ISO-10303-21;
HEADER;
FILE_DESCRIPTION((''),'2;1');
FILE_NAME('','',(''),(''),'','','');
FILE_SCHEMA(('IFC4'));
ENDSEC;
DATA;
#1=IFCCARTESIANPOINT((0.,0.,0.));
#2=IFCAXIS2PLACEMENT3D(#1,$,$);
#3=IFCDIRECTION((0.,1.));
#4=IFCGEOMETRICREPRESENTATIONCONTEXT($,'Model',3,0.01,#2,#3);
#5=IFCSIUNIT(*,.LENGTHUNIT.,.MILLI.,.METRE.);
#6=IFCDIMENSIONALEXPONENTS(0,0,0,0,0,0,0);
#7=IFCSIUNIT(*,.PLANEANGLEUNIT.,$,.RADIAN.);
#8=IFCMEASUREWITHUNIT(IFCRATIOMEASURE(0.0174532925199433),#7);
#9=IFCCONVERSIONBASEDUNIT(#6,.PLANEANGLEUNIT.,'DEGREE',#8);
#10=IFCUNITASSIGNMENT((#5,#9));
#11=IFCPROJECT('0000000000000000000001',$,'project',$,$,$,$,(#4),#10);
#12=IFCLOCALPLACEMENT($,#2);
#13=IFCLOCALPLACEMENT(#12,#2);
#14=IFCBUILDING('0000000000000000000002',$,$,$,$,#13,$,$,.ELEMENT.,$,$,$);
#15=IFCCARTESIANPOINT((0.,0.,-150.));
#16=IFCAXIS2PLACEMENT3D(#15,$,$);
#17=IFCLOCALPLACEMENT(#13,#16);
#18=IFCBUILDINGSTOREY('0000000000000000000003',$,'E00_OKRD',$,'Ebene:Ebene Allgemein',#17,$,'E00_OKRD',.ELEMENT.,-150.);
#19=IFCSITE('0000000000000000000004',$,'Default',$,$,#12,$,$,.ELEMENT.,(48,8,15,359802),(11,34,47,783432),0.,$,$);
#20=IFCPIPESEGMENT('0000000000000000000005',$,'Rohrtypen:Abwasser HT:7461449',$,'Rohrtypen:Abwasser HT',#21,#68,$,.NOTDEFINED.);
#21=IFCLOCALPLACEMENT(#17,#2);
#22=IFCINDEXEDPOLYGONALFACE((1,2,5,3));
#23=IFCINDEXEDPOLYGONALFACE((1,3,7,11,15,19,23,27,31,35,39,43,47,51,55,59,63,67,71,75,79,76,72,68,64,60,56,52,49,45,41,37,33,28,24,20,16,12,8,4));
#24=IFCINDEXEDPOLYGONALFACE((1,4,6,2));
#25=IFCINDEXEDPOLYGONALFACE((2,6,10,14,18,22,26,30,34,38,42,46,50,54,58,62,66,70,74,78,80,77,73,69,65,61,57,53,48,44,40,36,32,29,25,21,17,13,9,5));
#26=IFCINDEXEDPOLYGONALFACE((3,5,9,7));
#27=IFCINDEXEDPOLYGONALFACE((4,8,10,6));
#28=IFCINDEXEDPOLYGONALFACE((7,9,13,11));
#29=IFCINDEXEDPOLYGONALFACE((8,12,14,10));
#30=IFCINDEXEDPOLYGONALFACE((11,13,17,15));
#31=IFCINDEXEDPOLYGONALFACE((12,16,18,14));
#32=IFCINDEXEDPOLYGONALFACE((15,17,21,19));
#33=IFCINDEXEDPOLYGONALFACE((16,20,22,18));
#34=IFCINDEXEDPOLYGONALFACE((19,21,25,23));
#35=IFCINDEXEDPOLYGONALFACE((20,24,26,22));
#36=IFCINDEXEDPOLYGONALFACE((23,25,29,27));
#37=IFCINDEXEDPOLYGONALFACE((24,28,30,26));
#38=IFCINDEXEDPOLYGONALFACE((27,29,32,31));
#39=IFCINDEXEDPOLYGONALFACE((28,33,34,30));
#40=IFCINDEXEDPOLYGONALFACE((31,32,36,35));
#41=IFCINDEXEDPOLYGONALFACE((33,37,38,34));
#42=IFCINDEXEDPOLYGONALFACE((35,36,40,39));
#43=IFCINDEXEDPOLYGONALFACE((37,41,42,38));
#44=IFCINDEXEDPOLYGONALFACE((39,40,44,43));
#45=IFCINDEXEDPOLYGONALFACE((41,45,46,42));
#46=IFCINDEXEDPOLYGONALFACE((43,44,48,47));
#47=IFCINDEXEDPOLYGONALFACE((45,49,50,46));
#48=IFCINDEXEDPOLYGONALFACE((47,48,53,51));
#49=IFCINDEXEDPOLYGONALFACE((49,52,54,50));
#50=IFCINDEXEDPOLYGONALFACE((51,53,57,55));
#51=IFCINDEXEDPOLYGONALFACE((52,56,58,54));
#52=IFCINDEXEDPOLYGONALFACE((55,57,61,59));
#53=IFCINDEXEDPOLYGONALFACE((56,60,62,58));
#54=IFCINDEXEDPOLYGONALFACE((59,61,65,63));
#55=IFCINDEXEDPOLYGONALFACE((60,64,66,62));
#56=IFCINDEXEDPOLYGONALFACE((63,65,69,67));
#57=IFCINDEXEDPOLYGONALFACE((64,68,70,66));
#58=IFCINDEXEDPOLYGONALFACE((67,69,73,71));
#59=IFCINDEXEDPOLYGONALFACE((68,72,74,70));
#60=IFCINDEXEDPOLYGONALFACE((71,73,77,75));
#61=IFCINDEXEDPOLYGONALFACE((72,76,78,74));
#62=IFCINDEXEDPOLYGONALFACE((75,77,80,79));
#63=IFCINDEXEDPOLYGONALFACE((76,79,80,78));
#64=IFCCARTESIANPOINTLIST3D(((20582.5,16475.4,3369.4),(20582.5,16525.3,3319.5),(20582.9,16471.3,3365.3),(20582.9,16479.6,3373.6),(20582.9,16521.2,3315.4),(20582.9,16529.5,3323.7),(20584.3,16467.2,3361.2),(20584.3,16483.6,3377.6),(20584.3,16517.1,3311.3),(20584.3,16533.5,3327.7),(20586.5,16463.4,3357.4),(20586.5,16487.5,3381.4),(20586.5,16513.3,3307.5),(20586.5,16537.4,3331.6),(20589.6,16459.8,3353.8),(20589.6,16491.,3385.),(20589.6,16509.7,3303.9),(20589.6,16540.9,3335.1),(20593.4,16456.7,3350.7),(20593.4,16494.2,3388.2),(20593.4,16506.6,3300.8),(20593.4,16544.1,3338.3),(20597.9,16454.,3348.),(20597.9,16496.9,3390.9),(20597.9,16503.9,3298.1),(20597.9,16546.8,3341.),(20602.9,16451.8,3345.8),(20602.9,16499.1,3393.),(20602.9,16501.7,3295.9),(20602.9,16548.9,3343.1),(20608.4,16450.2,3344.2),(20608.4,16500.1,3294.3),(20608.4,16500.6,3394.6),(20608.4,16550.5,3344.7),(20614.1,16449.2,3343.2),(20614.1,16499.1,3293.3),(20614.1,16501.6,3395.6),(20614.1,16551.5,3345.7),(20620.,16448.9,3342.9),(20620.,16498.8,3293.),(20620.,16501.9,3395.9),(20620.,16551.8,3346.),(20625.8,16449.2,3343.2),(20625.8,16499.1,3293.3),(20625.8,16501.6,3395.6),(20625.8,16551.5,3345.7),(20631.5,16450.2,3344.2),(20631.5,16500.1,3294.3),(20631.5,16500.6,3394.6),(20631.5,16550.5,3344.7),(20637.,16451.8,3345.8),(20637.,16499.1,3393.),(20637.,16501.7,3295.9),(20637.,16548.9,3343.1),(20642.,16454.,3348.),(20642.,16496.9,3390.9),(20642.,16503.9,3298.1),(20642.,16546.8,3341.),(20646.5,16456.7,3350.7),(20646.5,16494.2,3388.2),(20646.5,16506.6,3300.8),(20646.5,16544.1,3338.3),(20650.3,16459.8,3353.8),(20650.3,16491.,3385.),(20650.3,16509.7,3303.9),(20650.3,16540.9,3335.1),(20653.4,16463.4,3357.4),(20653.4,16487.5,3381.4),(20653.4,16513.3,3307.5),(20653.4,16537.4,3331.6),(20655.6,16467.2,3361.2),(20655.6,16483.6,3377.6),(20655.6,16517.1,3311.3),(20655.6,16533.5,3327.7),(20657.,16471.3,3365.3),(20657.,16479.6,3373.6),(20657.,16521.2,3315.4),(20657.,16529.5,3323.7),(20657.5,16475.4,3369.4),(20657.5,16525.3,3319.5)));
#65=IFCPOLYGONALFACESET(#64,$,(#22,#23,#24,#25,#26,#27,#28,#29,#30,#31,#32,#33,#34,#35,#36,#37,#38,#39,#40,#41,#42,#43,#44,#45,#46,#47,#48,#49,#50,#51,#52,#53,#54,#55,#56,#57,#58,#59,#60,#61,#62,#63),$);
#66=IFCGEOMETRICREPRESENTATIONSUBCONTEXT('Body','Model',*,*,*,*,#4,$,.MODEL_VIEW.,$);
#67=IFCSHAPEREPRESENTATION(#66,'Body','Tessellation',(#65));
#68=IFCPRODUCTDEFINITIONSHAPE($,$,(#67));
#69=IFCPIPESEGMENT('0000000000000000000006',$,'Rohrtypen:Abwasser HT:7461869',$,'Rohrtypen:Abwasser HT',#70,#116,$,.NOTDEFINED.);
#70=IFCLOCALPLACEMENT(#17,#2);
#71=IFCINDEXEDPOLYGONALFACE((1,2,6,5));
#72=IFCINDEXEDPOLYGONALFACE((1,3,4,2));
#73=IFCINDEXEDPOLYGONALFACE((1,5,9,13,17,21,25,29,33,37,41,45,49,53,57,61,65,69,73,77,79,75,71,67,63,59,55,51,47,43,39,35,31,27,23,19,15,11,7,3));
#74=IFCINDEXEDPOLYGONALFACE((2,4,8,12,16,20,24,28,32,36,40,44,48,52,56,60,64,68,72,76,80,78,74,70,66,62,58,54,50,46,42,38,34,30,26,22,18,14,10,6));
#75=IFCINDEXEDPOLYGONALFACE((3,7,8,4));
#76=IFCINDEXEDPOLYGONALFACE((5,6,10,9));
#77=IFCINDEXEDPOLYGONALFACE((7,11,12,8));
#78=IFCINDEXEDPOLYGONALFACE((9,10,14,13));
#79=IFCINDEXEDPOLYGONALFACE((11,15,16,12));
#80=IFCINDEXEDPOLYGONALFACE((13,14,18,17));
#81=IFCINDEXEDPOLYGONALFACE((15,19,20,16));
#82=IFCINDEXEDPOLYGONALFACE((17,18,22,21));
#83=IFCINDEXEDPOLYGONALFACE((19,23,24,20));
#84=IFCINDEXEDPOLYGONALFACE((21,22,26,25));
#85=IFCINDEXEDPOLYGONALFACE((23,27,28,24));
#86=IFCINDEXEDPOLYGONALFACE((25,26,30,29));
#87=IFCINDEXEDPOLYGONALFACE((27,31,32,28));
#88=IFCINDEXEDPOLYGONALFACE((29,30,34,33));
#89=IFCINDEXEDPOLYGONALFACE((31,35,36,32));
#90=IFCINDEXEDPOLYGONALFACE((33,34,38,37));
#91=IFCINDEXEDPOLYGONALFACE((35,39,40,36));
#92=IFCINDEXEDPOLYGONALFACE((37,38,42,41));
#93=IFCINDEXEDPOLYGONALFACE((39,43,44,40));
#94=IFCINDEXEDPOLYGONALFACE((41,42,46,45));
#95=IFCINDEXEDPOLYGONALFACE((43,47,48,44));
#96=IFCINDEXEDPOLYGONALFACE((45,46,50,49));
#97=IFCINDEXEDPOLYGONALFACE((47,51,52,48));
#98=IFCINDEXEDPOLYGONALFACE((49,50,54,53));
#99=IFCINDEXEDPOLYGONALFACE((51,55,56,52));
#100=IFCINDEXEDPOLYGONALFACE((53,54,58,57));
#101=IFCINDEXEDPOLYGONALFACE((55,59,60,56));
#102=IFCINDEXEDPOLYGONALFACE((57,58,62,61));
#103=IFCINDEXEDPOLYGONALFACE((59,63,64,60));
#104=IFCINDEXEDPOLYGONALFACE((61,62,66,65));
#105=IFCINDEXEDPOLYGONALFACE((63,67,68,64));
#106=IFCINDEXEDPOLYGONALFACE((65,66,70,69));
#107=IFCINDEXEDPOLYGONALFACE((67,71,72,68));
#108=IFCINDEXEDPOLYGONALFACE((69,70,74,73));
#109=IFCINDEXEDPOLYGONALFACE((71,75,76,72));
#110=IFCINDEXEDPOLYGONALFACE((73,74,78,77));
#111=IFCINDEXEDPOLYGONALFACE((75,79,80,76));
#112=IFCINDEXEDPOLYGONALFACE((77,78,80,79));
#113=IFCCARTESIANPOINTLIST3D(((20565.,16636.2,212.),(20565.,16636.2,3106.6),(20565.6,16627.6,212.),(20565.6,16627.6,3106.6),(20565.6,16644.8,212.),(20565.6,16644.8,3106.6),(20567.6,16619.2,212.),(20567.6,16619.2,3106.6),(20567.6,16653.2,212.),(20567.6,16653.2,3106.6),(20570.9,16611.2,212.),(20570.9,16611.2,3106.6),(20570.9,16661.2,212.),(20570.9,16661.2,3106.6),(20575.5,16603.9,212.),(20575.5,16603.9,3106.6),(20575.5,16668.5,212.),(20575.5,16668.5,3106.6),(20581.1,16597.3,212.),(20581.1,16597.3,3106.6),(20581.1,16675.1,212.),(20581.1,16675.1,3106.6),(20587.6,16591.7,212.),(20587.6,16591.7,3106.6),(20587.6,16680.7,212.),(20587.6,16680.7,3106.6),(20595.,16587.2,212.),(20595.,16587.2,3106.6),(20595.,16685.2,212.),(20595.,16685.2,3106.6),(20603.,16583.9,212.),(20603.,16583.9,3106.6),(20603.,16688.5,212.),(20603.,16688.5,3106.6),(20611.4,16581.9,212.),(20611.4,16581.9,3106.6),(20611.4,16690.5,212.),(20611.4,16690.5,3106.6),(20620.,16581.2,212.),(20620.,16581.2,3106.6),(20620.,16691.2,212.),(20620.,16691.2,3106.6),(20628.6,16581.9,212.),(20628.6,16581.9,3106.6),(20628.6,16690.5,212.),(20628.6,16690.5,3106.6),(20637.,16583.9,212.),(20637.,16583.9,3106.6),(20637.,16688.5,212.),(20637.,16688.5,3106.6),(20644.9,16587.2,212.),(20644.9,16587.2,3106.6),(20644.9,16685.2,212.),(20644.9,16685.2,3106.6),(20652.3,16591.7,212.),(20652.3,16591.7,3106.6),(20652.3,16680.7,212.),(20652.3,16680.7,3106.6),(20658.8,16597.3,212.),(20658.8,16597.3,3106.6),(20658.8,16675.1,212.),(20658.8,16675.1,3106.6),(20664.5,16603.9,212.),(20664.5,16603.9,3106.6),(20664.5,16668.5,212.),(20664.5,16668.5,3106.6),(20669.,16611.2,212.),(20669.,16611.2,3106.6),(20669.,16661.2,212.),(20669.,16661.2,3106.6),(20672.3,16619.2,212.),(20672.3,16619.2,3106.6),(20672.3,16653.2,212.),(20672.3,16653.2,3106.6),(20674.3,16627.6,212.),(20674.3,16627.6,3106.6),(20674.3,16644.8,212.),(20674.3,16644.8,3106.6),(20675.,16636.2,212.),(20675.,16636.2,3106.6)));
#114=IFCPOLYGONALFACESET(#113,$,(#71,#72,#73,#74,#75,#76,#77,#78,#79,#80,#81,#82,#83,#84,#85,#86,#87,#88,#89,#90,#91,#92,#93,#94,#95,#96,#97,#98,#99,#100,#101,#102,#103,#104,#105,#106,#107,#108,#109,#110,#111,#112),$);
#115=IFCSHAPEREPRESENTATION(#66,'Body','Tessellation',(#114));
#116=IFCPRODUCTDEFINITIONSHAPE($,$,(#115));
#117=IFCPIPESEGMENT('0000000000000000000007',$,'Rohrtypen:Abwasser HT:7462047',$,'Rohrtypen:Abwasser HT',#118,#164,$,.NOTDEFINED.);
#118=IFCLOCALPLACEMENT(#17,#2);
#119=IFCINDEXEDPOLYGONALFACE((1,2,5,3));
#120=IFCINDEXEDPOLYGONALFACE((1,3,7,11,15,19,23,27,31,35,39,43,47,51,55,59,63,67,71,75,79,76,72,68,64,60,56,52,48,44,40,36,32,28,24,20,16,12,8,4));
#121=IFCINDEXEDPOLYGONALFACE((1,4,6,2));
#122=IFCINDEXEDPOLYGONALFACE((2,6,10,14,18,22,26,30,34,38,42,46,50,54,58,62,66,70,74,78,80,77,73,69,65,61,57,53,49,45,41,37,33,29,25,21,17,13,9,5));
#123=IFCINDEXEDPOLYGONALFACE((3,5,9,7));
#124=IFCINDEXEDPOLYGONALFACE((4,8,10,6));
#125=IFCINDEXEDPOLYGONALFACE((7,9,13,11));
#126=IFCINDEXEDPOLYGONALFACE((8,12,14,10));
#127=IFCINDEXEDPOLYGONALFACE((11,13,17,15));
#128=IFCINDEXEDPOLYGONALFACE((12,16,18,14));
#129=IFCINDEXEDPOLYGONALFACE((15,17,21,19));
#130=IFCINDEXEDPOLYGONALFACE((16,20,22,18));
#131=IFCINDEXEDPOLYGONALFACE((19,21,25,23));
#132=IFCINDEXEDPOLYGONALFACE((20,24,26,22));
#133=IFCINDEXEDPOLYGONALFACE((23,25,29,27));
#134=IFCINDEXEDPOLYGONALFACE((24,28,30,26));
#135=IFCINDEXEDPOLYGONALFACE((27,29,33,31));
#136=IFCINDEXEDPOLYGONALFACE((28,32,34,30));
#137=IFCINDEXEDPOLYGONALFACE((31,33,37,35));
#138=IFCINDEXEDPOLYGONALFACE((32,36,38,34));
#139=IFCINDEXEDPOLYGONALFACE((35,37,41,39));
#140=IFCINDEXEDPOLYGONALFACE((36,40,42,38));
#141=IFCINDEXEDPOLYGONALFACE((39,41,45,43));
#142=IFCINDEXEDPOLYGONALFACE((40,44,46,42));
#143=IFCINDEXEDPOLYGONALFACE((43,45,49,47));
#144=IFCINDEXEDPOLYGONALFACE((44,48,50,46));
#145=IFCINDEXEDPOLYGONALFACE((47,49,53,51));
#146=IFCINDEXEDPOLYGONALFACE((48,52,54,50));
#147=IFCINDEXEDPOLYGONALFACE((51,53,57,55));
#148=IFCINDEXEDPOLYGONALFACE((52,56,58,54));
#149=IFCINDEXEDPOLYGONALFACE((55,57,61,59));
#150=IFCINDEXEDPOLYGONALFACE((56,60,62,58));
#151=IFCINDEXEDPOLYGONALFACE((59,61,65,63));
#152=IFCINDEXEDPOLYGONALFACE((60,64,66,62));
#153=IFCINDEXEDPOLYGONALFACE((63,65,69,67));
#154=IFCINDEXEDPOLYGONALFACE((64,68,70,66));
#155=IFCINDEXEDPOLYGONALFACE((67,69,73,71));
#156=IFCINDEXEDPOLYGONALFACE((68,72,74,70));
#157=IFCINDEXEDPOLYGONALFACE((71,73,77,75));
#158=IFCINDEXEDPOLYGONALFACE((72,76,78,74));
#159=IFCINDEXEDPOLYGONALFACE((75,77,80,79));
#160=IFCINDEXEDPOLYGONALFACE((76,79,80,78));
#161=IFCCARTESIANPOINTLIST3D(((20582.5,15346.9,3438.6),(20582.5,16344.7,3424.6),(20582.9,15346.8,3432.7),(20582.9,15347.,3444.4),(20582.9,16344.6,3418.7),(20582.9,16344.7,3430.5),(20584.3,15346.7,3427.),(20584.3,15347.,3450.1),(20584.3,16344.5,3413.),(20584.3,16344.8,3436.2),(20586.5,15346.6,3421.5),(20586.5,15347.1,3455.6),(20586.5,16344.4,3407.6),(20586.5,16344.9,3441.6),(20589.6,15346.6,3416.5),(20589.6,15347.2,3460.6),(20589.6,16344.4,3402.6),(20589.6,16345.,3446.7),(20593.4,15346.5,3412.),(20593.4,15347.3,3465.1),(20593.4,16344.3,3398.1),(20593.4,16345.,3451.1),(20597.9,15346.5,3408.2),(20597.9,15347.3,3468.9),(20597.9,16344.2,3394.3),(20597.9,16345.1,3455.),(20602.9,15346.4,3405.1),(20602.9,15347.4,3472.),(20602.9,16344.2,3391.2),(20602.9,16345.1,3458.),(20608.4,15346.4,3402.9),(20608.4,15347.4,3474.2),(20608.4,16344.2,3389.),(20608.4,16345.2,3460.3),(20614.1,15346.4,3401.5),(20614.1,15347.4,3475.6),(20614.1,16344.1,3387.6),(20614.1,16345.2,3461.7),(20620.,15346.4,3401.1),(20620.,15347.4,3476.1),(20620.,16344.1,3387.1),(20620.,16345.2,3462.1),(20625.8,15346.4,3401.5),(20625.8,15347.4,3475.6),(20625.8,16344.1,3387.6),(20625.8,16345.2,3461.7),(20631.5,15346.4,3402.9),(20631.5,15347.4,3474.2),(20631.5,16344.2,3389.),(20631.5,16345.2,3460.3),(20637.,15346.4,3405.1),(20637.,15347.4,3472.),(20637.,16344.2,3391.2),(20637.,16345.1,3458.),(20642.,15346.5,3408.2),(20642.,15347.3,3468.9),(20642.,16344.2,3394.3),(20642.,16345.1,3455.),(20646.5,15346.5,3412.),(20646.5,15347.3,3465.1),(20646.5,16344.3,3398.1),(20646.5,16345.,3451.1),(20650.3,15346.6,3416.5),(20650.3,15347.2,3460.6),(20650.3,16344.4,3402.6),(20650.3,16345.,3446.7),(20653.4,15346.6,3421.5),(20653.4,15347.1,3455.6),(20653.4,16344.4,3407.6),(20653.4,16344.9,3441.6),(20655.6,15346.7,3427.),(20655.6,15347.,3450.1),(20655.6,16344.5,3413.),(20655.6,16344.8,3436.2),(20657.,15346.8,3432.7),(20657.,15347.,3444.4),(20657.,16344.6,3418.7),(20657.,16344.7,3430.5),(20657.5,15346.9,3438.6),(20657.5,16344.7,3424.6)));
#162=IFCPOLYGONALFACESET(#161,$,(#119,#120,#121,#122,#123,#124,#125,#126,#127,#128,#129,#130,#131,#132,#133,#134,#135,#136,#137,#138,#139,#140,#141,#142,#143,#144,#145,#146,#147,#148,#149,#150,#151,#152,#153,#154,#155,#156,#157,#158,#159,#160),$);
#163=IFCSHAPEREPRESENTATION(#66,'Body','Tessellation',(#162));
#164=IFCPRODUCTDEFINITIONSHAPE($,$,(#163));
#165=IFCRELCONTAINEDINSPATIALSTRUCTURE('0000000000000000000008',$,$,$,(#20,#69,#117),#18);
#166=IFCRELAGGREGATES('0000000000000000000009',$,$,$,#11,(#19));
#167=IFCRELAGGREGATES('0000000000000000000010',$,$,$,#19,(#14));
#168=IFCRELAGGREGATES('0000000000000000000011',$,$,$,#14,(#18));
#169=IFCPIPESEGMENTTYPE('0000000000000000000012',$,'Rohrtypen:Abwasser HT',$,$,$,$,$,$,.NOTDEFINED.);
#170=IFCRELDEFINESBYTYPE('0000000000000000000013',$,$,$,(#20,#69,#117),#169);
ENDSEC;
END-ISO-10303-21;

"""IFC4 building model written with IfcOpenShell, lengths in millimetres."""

from ifc_helpers import new_model, entity, si_unit, converted_unit, direction, frame, origin, place, context, subcontext, project, spatial, indexed_curve, outline, extrude, type_object, element, save


model = new_model("IFC4")

# Units and contexts
model_context = context("Model", 3, precision=0.01, world=origin(), true_north=direction((0.0, 1.0)))
body_context = subcontext(model_context, "Body", "Model", "MODEL_VIEW")
ifc_project = project(units=[si_unit("LENGTHUNIT", "METRE", prefix="MILLI"), converted_unit("PLANEANGLEUNIT", "DEGREE", entity("IfcRatioMeasure", 0.0174532925199433), si_unit("PLANEANGLEUNIT", "RADIAN"), dimensions=[0, 0, 0, 0, 0, 0, 0])], contexts=[model_context])

# Site, building, storey
site_placement = place(None, origin())
site = spatial("IfcSite", under=ifc_project, at=site_placement, Name="Default", CompositionType="ELEMENT", RefLatitude=(48, 8, 15, 359802), RefLongitude=(11, 34, 47, 783432), RefElevation=0.0)
building_placement = place(site_placement, origin())
building = spatial("IfcBuilding", under=site, at=building_placement, CompositionType="ELEMENT")
storey_placement = place(building_placement, frame((0.0, 0.0, -150.0)))
storey = spatial("IfcBuildingStorey", under=building, at=storey_placement, Name="E00_OKRD", ObjectType="Ebene:Ebene Allgemein", LongName="E00_OKRD", CompositionType="ELEMENT", Elevation=-150.0)

# Pipe segments
pipe_segment_type_1 = type_object("IfcPipeSegmentType", Name="Rohrtypen:Abwasser HT", PredefinedType="NOTDEFINED")
pipe_segment_1_placement = place(storey_placement, origin())
element("IfcPipeSegment", 1, at=pipe_segment_1_placement, inside=storey, type_object=pipe_segment_type_1, Name="Rohrtypen:Abwasser HT:7461449", ObjectType="Rohrtypen:Abwasser HT", PredefinedType="NOTDEFINED", context=body_context, shape_type="SweptSolid", body=[
    extrude(outline(indexed_curve([(37.5, 0.0), (37.0, 5.9), (35.7, 11.6), (33.4, 17.0), (30.3, 22.0), (26.5, 26.5), (22.0, 30.3), (17.0, 33.4), (11.6, 35.7), (5.9, 37.0), (0.0, 37.5), (-5.9, 37.0), (-11.6, 35.7), (-17.0, 33.4), (-22.0, 30.3), (-26.5, 26.5), (-30.3, 22.0), (-33.4, 17.0), (-35.7, 11.6), (-37.0, 5.9), (-37.5, 0.0), (-37.0, -5.9), (-35.7, -11.6), (-33.4, -17.0), (-30.3, -22.0), (-26.5, -26.5), (-22.0, -30.3), (-17.0, -33.4), (-11.6, -35.7), (-5.9, -37.0), (0.0, -37.5), (5.9, -37.0), (11.6, -35.7), (17.0, -33.4), (22.0, -30.3), (26.5, -26.5), (30.3, -22.0), (33.4, -17.0), (35.7, -11.6), (37.0, -5.9), (37.5, 0.0)], self_intersect=False)), frame((20620.0, 16525.3, 3319.5), z_axis=(0.0, -0.707107, 0.707107), x_axis=(-1.0, 0.0, 0.0)), (0.0, 0.0, 1.0), 70.6),
])
pipe_segment_2_placement = place(storey_placement, origin())
element("IfcPipeSegment", 2, at=pipe_segment_2_placement, inside=storey, type_object=pipe_segment_type_1, Name="Rohrtypen:Abwasser HT:7461869", ObjectType="Rohrtypen:Abwasser HT", PredefinedType="NOTDEFINED", context=body_context, shape_type="SweptSolid", body=[
    extrude(outline(indexed_curve([(55.0, 0.0), (54.3, 8.6), (52.3, 17.0), (49.0, 25.0), (44.5, 32.3), (38.9, 38.9), (32.3, 44.5), (25.0, 49.0), (17.0, 52.3), (8.6, 54.3), (0.0, 55.0), (-8.6, 54.3), (-17.0, 52.3), (-25.0, 49.0), (-32.3, 44.5), (-38.9, 38.9), (-44.5, 32.3), (-49.0, 25.0), (-52.3, 17.0), (-54.3, 8.6), (-55.0, 0.0), (-54.3, -8.6), (-52.3, -17.0), (-49.0, -25.0), (-44.5, -32.3), (-38.9, -38.9), (-32.3, -44.5), (-25.0, -49.0), (-17.0, -52.3), (-8.6, -54.3), (0.0, -55.0), (8.6, -54.3), (17.0, -52.3), (25.0, -49.0), (32.3, -44.5), (38.9, -38.9), (44.5, -32.3), (49.0, -25.0), (52.3, -17.0), (54.3, -8.6), (55.0, 0.0)], self_intersect=False)), frame((20620.0, 16636.2, 212.0), z_axis=(0.0, 0.0, 1.0), x_axis=(-1.0, 0.0, 0.0)), (0.0, 0.0, 1.0), 2894.7),
])
pipe_segment_3_placement = place(storey_placement, origin())
element("IfcPipeSegment", 3, at=pipe_segment_3_placement, inside=storey, type_object=pipe_segment_type_1, Name="Rohrtypen:Abwasser HT:7462047", ObjectType="Rohrtypen:Abwasser HT", PredefinedType="NOTDEFINED", context=body_context, shape_type="SweptSolid", body=[
    extrude(outline(indexed_curve([(37.5, 0.0), (37.0, 5.9), (35.7, 11.6), (33.4, 17.0), (30.3, 22.0), (26.5, 26.5), (22.0, 30.3), (17.0, 33.4), (11.6, 35.7), (5.9, 37.0), (0.0, 37.5), (-5.9, 37.0), (-11.6, 35.7), (-17.0, 33.4), (-22.0, 30.3), (-26.5, 26.5), (-30.3, 22.0), (-33.4, 17.0), (-35.7, 11.6), (-37.0, 5.9), (-37.5, 0.0), (-37.0, -5.9), (-35.7, -11.6), (-33.4, -17.0), (-30.3, -22.0), (-26.5, -26.5), (-22.0, -30.3), (-17.0, -33.4), (-11.6, -35.7), (-5.9, -37.0), (0.0, -37.5), (5.9, -37.0), (11.6, -35.7), (17.0, -33.4), (22.0, -30.3), (26.5, -26.5), (30.3, -22.0), (33.4, -17.0), (35.7, -11.6), (37.0, -5.9), (37.5, 0.0)], self_intersect=False)), frame((20620.0, 16344.7, 3424.6), z_axis=(0.0, -0.999902, 0.01397), x_axis=(1.0, 0.0, 0.0)), (0.0, 0.0, 1.0), 997.9),
])

save(model, "model.ifc")
